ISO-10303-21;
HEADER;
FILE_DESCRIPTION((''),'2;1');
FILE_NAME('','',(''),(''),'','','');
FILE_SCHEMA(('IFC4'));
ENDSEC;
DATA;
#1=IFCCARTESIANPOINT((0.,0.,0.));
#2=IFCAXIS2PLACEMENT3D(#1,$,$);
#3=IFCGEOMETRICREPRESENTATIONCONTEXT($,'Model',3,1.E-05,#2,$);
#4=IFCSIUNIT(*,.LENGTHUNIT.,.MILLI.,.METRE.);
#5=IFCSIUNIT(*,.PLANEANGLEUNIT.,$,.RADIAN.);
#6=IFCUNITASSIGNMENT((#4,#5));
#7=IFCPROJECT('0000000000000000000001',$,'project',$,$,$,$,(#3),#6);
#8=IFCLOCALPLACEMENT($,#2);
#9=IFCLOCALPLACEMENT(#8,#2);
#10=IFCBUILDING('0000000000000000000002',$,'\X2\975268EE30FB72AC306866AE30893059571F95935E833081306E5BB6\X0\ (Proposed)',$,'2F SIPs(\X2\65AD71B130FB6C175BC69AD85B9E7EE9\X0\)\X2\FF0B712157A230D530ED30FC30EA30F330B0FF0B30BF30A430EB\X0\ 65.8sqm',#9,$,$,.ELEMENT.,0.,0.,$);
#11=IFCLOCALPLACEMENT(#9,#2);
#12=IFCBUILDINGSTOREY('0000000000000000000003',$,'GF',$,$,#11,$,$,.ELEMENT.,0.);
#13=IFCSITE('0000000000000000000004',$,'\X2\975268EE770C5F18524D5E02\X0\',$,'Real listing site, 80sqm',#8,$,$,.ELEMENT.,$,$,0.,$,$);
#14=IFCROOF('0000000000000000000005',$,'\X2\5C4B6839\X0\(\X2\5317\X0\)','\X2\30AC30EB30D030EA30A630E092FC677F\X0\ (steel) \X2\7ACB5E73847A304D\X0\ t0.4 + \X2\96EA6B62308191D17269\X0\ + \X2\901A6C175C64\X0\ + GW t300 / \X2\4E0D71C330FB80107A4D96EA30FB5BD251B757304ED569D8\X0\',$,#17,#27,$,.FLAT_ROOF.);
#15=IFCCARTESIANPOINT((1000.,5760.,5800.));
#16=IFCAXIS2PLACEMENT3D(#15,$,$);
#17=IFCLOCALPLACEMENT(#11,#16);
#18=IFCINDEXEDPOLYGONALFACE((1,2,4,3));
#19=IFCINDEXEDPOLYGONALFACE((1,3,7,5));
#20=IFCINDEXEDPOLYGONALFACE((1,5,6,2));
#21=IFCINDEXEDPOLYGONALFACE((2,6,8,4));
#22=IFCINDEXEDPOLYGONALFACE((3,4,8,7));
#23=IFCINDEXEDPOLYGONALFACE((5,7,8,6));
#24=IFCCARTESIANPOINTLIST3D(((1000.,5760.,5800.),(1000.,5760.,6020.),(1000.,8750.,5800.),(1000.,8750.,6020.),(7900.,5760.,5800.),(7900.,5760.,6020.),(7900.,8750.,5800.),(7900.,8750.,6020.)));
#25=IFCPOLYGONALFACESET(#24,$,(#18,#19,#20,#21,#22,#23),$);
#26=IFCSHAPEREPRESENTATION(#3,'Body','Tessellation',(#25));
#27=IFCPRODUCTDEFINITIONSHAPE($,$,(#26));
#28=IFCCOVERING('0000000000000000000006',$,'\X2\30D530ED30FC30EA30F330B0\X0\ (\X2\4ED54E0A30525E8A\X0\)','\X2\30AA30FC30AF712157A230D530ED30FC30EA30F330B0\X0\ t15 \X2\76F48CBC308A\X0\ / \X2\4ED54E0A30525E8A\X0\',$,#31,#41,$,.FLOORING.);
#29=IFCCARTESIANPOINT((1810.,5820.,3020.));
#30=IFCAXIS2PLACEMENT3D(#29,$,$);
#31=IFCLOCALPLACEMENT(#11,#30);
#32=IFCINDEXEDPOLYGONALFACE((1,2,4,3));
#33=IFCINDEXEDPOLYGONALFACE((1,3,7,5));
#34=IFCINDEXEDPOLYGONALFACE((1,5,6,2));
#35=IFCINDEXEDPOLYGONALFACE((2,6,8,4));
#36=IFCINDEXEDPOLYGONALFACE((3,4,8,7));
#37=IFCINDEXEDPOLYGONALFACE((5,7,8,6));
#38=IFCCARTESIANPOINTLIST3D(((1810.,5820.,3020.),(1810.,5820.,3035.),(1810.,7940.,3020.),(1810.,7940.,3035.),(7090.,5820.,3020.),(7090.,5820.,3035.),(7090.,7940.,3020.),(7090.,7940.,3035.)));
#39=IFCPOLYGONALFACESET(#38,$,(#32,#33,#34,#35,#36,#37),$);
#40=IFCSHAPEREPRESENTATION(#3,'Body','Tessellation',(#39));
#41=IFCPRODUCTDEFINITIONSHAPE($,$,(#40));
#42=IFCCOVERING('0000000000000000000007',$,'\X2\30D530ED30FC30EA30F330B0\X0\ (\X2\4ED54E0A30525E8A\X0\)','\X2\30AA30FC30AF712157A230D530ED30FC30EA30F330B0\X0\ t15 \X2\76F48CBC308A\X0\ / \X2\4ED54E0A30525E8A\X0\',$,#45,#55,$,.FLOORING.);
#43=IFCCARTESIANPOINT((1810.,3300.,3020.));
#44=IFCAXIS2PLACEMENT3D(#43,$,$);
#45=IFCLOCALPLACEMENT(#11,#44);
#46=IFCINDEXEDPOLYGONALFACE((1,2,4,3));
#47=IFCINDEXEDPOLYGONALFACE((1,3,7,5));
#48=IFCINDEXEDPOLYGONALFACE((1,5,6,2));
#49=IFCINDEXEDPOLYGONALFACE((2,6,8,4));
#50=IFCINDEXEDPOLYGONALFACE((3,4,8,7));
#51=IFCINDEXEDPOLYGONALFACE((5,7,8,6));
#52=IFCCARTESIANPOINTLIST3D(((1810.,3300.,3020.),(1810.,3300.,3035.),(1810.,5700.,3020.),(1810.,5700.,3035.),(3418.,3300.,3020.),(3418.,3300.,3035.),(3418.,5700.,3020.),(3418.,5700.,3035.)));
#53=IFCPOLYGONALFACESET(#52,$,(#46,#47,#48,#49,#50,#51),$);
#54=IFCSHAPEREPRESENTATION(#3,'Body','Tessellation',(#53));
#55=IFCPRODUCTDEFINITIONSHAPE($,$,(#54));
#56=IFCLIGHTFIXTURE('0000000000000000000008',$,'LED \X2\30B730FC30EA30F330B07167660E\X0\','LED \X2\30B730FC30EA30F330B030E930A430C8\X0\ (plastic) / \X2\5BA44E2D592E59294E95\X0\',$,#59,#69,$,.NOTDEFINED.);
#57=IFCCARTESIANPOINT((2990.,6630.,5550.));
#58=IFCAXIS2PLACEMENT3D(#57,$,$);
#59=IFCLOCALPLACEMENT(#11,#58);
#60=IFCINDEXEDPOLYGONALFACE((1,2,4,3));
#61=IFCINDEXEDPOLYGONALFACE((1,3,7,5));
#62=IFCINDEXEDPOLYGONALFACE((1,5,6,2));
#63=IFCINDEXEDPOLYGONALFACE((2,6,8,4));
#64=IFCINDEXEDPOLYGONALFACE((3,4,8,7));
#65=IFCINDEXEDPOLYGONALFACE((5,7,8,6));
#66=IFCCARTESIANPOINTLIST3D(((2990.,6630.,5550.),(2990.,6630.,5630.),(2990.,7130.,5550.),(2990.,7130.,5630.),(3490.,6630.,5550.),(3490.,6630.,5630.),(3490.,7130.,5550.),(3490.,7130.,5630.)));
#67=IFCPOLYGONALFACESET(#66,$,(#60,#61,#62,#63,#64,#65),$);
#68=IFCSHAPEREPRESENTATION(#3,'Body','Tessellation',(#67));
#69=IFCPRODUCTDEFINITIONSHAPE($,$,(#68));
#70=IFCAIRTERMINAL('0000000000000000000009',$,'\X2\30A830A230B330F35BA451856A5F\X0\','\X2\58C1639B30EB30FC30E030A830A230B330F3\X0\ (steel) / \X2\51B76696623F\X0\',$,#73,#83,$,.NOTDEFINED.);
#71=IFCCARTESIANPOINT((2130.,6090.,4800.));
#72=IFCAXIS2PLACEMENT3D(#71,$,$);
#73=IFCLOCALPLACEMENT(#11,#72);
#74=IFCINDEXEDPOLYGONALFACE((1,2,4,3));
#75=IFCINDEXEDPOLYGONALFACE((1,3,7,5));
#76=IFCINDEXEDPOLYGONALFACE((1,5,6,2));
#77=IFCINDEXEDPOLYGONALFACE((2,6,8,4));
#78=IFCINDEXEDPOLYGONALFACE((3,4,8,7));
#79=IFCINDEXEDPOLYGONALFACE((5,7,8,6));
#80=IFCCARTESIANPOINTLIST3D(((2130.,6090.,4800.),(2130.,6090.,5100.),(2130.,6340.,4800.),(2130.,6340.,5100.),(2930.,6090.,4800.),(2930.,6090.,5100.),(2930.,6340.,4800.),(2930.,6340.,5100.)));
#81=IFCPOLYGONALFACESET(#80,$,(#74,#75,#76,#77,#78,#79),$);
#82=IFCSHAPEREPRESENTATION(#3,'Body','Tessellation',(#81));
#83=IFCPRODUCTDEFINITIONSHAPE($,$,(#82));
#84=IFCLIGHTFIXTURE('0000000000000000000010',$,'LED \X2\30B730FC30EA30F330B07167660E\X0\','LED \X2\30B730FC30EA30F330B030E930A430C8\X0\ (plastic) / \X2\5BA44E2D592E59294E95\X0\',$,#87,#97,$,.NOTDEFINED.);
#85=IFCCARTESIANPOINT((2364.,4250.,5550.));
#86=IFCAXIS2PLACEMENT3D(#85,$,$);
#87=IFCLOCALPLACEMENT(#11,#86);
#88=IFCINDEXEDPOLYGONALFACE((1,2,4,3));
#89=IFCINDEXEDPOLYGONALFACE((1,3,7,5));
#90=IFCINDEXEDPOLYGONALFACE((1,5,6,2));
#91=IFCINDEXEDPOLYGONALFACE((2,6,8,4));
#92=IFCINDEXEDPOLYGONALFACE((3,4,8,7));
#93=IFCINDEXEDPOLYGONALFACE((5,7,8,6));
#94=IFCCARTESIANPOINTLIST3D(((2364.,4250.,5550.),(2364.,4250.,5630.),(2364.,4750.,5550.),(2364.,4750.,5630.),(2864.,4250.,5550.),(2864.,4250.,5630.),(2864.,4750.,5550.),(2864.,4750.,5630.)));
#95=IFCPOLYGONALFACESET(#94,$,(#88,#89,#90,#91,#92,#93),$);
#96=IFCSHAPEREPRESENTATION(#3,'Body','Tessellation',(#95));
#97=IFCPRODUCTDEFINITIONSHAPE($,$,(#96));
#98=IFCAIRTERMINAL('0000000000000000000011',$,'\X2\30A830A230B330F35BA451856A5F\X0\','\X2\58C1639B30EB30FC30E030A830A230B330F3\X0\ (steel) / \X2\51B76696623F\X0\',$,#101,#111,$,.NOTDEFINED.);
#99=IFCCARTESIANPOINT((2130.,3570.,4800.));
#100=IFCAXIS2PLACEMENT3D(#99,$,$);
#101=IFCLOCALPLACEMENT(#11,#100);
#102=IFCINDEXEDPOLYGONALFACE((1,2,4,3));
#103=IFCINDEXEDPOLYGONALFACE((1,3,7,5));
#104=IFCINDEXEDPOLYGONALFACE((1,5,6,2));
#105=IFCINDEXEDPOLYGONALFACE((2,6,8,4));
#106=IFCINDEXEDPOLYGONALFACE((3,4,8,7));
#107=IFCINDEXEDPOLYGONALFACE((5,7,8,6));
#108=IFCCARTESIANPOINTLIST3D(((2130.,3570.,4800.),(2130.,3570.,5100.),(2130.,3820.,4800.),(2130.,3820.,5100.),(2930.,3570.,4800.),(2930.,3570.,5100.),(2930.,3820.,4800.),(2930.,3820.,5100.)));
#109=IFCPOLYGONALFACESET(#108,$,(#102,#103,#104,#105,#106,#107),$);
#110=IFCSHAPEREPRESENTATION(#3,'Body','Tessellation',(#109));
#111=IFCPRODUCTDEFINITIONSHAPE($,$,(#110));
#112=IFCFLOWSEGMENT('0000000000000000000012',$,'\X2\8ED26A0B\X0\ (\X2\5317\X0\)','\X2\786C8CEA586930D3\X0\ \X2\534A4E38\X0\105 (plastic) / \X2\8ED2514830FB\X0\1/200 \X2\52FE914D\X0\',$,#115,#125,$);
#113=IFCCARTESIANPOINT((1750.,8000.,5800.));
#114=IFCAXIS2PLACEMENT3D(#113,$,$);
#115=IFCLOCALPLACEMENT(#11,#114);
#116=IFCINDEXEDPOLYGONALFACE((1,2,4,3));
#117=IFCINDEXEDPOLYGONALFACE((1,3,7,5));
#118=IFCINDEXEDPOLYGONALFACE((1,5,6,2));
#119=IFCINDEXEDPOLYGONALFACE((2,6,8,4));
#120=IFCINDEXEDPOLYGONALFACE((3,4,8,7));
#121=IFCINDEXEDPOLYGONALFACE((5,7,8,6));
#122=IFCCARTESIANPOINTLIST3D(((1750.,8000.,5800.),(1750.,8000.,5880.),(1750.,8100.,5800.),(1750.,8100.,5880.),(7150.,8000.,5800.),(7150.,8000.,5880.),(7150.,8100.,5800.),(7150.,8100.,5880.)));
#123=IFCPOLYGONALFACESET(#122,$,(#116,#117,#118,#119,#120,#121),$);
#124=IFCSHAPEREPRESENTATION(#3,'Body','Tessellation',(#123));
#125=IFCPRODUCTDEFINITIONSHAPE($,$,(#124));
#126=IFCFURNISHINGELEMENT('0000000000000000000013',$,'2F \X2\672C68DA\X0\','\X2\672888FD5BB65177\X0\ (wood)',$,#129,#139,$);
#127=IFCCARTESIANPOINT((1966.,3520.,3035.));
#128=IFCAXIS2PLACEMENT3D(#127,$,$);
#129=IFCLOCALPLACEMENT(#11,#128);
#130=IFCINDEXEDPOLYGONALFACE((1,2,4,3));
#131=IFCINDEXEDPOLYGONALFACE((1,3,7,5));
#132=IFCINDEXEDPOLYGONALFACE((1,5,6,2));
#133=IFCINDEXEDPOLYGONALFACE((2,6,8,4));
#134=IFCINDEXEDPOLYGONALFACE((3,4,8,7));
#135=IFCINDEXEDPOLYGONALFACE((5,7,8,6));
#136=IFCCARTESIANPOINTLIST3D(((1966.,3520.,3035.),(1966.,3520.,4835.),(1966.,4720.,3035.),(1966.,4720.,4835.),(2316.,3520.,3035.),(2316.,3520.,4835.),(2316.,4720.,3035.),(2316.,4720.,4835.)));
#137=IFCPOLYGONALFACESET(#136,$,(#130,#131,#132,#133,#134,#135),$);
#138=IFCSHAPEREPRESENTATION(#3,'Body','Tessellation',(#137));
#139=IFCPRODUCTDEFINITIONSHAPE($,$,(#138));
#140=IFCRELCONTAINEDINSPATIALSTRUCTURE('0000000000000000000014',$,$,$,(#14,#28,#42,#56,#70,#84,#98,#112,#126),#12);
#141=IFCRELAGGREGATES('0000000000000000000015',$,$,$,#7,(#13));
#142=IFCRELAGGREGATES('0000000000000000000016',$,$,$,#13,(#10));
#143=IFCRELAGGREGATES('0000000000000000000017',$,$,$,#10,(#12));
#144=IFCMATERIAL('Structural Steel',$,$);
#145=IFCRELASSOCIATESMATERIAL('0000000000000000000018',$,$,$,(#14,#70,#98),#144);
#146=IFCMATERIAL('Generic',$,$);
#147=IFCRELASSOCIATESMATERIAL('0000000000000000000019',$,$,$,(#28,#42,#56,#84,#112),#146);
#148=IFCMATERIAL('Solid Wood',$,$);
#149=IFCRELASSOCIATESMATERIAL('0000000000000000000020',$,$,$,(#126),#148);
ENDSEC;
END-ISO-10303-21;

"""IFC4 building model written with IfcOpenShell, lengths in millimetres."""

from ifc_helpers import new_model, si_unit, frame, frame_2d, origin, place, context, project, spatial, rectangle, extrude, material, element, save


model = new_model("IFC4")

# Units and contexts
model_context = context("Model", 3, precision=1e-05, world=origin())
ifc_project = project(units=[si_unit("LENGTHUNIT", "METRE", prefix="MILLI"), si_unit("PLANEANGLEUNIT", "RADIAN")], contexts=[model_context])

# Site, building, storey
site_placement = place(None, origin())
site = spatial("IfcSite", under=ifc_project, at=site_placement, Name="青森県弘前市", ObjectType="Real listing site, 80sqm", CompositionType="ELEMENT", RefElevation=0.0)
building_placement = place(site_placement, origin())
building = spatial("IfcBuilding", under=site, at=building_placement, Name="青森・犬と暮らす土間広めの家 (Proposed)", ObjectType="2F SIPs(断熱・気密高实绩)＋無垢フローリング＋タイル 65.8sqm", CompositionType="ELEMENT", ElevationOfRefHeight=0.0, ElevationOfTerrain=0.0)
storey_placement = place(building_placement, origin())
storey = spatial("IfcBuildingStorey", under=building, at=storey_placement, Name="GF", CompositionType="ELEMENT", Elevation=0.0)

# Shared definitions
ifc_material_1 = material(Name="Solid Wood")

# Roof
ifc_material_2 = material(Name="Structural Steel")
for number, where, name in (
    (1, (1000.0, 5760.0, 5800.0), "屋根(北)"),
):
    element("IfcRoof", number, at=place(storey_placement, frame(where)), inside=storey, material=ifc_material_2, Name=name, Description="ガルバリウム鋼板 (steel) 立平葺き t0.4 + 雪止め金物 + 通気層 + GW t300 / 不燃・耐積雪・寒冷地仕様", PredefinedType="FLAT_ROOF", context=model_context, shape_type="SweptSolid", body=[
        extrude(rectangle(XDim=6900.0, YDim=2990.0, at=frame_2d((3450.0, 1495.0))), frame((1000.0, 5760.0, 5800.0)), (0.0, 0.0, 1.0), 220.0),
    ])

# Coverings
ifc_material_3 = material(Name="Generic")
covering_1_placement = place(storey_placement, frame((1810.0, 5820.0, 3020.0)))
element("IfcCovering", 2, at=covering_1_placement, inside=storey, material=ifc_material_3, Name="フローリング (仕上げ床)", Description="オーク無垢フローリング t15 直貼り / 仕上げ床", PredefinedType="FLOORING", context=model_context, shape_type="SweptSolid", body=[
    extrude(rectangle(XDim=5280.0, YDim=2120.0, at=frame_2d((2640.0, 1060.0))), frame((1810.0, 5820.0, 3020.0)), (0.0, 0.0, 1.0), 15.0),
])
covering_2_placement = place(storey_placement, frame((1810.0, 3300.0, 3020.0)))
element("IfcCovering", 3, at=covering_2_placement, inside=storey, material=ifc_material_3, Name="フローリング (仕上げ床)", Description="オーク無垢フローリング t15 直貼り / 仕上げ床", PredefinedType="FLOORING", context=model_context, shape_type="SweptSolid", body=[
    extrude(rectangle(XDim=1608.0, YDim=2400.0, at=frame_2d((804.0, 1200.0))), frame((1810.0, 3300.0, 3020.0)), (0.0, 0.0, 1.0), 15.0),
])

# Light fixture
light_fixture_1_placement = place(storey_placement, frame((2990.0, 6630.0, 5550.0)))
element("IfcLightFixture", 4, at=light_fixture_1_placement, inside=storey, material=ifc_material_3, Name="LED シーリング照明", Description="LED シーリングライト (plastic) / 室中央天井", PredefinedType="NOTDEFINED", context=model_context, shape_type="SweptSolid", body=[
    extrude(rectangle(XDim=500.0, YDim=500.0, at=frame_2d((250.0, 250.0))), frame((2990.0, 6630.0, 5550.0)), (0.0, 0.0, 1.0), 80.0),
])

# Air terminal
air_terminal_1_placement = place(storey_placement, frame((2130.0, 6090.0, 4800.0)))
element("IfcAirTerminal", 5, at=air_terminal_1_placement, inside=storey, material=ifc_material_2, Name="エアコン室内機", Description="壁掛ルームエアコン (steel) / 冷暖房", PredefinedType="NOTDEFINED", context=model_context, shape_type="SweptSolid", body=[
    extrude(rectangle(XDim=800.0, YDim=250.0, at=frame_2d((400.0, 125.0))), frame((2130.0, 6090.0, 4800.0)), (0.0, 0.0, 1.0), 300.0),
])

# Light fixture
light_fixture_2_placement = place(storey_placement, frame((2364.0, 4250.0, 5550.0)))
element("IfcLightFixture", 6, at=light_fixture_2_placement, inside=storey, material=ifc_material_3, Name="LED シーリング照明", Description="LED シーリングライト (plastic) / 室中央天井", PredefinedType="NOTDEFINED", context=model_context, shape_type="SweptSolid", body=[
    extrude(rectangle(XDim=500.0, YDim=500.0, at=frame_2d((250.0, 250.0))), frame((2364.0, 4250.0, 5550.0)), (0.0, 0.0, 1.0), 80.0),
])

# Air terminal
air_terminal_2_placement = place(storey_placement, frame((2130.0, 3570.0, 4800.0)))
element("IfcAirTerminal", 7, at=air_terminal_2_placement, inside=storey, material=ifc_material_2, Name="エアコン室内機", Description="壁掛ルームエアコン (steel) / 冷暖房", PredefinedType="NOTDEFINED", context=model_context, shape_type="SweptSolid", body=[
    extrude(rectangle(XDim=800.0, YDim=250.0, at=frame_2d((400.0, 125.0))), frame((2130.0, 3570.0, 4800.0)), (0.0, 0.0, 1.0), 300.0),
])

# Flow segment
flow_segment_placement = place(storey_placement, frame((1750.0, 8000.0, 5800.0)))
element("IfcFlowSegment", 8, at=flow_segment_placement, inside=storey, material=ifc_material_3, Name="軒樋 (北)", Description="硬質塩ビ 半丸105 (plastic) / 軒先・1/200 勾配", context=model_context, shape_type="SweptSolid", body=[
    extrude(rectangle(XDim=5400.0, YDim=100.0, at=frame_2d((2700.0, 50.0))), frame((1750.0, 8000.0, 5800.0)), (0.0, 0.0, 1.0), 80.0),
])

# Furnishing element
furnishing_placement = place(storey_placement, frame((1966.0, 3520.0, 3035.0)))
element("IfcFurnishingElement", 9, at=furnishing_placement, inside=storey, material=ifc_material_1, Name="2F 本棚", Description="木製家具 (wood)", context=model_context, shape_type="SweptSolid", body=[
    extrude(rectangle(XDim=350.0, YDim=1200.0, at=frame_2d((175.0, 600.0))), frame((1966.0, 3520.0, 3035.0)), (0.0, 0.0, 1.0), 1800.0),
])

save(model, "model.ifc")
